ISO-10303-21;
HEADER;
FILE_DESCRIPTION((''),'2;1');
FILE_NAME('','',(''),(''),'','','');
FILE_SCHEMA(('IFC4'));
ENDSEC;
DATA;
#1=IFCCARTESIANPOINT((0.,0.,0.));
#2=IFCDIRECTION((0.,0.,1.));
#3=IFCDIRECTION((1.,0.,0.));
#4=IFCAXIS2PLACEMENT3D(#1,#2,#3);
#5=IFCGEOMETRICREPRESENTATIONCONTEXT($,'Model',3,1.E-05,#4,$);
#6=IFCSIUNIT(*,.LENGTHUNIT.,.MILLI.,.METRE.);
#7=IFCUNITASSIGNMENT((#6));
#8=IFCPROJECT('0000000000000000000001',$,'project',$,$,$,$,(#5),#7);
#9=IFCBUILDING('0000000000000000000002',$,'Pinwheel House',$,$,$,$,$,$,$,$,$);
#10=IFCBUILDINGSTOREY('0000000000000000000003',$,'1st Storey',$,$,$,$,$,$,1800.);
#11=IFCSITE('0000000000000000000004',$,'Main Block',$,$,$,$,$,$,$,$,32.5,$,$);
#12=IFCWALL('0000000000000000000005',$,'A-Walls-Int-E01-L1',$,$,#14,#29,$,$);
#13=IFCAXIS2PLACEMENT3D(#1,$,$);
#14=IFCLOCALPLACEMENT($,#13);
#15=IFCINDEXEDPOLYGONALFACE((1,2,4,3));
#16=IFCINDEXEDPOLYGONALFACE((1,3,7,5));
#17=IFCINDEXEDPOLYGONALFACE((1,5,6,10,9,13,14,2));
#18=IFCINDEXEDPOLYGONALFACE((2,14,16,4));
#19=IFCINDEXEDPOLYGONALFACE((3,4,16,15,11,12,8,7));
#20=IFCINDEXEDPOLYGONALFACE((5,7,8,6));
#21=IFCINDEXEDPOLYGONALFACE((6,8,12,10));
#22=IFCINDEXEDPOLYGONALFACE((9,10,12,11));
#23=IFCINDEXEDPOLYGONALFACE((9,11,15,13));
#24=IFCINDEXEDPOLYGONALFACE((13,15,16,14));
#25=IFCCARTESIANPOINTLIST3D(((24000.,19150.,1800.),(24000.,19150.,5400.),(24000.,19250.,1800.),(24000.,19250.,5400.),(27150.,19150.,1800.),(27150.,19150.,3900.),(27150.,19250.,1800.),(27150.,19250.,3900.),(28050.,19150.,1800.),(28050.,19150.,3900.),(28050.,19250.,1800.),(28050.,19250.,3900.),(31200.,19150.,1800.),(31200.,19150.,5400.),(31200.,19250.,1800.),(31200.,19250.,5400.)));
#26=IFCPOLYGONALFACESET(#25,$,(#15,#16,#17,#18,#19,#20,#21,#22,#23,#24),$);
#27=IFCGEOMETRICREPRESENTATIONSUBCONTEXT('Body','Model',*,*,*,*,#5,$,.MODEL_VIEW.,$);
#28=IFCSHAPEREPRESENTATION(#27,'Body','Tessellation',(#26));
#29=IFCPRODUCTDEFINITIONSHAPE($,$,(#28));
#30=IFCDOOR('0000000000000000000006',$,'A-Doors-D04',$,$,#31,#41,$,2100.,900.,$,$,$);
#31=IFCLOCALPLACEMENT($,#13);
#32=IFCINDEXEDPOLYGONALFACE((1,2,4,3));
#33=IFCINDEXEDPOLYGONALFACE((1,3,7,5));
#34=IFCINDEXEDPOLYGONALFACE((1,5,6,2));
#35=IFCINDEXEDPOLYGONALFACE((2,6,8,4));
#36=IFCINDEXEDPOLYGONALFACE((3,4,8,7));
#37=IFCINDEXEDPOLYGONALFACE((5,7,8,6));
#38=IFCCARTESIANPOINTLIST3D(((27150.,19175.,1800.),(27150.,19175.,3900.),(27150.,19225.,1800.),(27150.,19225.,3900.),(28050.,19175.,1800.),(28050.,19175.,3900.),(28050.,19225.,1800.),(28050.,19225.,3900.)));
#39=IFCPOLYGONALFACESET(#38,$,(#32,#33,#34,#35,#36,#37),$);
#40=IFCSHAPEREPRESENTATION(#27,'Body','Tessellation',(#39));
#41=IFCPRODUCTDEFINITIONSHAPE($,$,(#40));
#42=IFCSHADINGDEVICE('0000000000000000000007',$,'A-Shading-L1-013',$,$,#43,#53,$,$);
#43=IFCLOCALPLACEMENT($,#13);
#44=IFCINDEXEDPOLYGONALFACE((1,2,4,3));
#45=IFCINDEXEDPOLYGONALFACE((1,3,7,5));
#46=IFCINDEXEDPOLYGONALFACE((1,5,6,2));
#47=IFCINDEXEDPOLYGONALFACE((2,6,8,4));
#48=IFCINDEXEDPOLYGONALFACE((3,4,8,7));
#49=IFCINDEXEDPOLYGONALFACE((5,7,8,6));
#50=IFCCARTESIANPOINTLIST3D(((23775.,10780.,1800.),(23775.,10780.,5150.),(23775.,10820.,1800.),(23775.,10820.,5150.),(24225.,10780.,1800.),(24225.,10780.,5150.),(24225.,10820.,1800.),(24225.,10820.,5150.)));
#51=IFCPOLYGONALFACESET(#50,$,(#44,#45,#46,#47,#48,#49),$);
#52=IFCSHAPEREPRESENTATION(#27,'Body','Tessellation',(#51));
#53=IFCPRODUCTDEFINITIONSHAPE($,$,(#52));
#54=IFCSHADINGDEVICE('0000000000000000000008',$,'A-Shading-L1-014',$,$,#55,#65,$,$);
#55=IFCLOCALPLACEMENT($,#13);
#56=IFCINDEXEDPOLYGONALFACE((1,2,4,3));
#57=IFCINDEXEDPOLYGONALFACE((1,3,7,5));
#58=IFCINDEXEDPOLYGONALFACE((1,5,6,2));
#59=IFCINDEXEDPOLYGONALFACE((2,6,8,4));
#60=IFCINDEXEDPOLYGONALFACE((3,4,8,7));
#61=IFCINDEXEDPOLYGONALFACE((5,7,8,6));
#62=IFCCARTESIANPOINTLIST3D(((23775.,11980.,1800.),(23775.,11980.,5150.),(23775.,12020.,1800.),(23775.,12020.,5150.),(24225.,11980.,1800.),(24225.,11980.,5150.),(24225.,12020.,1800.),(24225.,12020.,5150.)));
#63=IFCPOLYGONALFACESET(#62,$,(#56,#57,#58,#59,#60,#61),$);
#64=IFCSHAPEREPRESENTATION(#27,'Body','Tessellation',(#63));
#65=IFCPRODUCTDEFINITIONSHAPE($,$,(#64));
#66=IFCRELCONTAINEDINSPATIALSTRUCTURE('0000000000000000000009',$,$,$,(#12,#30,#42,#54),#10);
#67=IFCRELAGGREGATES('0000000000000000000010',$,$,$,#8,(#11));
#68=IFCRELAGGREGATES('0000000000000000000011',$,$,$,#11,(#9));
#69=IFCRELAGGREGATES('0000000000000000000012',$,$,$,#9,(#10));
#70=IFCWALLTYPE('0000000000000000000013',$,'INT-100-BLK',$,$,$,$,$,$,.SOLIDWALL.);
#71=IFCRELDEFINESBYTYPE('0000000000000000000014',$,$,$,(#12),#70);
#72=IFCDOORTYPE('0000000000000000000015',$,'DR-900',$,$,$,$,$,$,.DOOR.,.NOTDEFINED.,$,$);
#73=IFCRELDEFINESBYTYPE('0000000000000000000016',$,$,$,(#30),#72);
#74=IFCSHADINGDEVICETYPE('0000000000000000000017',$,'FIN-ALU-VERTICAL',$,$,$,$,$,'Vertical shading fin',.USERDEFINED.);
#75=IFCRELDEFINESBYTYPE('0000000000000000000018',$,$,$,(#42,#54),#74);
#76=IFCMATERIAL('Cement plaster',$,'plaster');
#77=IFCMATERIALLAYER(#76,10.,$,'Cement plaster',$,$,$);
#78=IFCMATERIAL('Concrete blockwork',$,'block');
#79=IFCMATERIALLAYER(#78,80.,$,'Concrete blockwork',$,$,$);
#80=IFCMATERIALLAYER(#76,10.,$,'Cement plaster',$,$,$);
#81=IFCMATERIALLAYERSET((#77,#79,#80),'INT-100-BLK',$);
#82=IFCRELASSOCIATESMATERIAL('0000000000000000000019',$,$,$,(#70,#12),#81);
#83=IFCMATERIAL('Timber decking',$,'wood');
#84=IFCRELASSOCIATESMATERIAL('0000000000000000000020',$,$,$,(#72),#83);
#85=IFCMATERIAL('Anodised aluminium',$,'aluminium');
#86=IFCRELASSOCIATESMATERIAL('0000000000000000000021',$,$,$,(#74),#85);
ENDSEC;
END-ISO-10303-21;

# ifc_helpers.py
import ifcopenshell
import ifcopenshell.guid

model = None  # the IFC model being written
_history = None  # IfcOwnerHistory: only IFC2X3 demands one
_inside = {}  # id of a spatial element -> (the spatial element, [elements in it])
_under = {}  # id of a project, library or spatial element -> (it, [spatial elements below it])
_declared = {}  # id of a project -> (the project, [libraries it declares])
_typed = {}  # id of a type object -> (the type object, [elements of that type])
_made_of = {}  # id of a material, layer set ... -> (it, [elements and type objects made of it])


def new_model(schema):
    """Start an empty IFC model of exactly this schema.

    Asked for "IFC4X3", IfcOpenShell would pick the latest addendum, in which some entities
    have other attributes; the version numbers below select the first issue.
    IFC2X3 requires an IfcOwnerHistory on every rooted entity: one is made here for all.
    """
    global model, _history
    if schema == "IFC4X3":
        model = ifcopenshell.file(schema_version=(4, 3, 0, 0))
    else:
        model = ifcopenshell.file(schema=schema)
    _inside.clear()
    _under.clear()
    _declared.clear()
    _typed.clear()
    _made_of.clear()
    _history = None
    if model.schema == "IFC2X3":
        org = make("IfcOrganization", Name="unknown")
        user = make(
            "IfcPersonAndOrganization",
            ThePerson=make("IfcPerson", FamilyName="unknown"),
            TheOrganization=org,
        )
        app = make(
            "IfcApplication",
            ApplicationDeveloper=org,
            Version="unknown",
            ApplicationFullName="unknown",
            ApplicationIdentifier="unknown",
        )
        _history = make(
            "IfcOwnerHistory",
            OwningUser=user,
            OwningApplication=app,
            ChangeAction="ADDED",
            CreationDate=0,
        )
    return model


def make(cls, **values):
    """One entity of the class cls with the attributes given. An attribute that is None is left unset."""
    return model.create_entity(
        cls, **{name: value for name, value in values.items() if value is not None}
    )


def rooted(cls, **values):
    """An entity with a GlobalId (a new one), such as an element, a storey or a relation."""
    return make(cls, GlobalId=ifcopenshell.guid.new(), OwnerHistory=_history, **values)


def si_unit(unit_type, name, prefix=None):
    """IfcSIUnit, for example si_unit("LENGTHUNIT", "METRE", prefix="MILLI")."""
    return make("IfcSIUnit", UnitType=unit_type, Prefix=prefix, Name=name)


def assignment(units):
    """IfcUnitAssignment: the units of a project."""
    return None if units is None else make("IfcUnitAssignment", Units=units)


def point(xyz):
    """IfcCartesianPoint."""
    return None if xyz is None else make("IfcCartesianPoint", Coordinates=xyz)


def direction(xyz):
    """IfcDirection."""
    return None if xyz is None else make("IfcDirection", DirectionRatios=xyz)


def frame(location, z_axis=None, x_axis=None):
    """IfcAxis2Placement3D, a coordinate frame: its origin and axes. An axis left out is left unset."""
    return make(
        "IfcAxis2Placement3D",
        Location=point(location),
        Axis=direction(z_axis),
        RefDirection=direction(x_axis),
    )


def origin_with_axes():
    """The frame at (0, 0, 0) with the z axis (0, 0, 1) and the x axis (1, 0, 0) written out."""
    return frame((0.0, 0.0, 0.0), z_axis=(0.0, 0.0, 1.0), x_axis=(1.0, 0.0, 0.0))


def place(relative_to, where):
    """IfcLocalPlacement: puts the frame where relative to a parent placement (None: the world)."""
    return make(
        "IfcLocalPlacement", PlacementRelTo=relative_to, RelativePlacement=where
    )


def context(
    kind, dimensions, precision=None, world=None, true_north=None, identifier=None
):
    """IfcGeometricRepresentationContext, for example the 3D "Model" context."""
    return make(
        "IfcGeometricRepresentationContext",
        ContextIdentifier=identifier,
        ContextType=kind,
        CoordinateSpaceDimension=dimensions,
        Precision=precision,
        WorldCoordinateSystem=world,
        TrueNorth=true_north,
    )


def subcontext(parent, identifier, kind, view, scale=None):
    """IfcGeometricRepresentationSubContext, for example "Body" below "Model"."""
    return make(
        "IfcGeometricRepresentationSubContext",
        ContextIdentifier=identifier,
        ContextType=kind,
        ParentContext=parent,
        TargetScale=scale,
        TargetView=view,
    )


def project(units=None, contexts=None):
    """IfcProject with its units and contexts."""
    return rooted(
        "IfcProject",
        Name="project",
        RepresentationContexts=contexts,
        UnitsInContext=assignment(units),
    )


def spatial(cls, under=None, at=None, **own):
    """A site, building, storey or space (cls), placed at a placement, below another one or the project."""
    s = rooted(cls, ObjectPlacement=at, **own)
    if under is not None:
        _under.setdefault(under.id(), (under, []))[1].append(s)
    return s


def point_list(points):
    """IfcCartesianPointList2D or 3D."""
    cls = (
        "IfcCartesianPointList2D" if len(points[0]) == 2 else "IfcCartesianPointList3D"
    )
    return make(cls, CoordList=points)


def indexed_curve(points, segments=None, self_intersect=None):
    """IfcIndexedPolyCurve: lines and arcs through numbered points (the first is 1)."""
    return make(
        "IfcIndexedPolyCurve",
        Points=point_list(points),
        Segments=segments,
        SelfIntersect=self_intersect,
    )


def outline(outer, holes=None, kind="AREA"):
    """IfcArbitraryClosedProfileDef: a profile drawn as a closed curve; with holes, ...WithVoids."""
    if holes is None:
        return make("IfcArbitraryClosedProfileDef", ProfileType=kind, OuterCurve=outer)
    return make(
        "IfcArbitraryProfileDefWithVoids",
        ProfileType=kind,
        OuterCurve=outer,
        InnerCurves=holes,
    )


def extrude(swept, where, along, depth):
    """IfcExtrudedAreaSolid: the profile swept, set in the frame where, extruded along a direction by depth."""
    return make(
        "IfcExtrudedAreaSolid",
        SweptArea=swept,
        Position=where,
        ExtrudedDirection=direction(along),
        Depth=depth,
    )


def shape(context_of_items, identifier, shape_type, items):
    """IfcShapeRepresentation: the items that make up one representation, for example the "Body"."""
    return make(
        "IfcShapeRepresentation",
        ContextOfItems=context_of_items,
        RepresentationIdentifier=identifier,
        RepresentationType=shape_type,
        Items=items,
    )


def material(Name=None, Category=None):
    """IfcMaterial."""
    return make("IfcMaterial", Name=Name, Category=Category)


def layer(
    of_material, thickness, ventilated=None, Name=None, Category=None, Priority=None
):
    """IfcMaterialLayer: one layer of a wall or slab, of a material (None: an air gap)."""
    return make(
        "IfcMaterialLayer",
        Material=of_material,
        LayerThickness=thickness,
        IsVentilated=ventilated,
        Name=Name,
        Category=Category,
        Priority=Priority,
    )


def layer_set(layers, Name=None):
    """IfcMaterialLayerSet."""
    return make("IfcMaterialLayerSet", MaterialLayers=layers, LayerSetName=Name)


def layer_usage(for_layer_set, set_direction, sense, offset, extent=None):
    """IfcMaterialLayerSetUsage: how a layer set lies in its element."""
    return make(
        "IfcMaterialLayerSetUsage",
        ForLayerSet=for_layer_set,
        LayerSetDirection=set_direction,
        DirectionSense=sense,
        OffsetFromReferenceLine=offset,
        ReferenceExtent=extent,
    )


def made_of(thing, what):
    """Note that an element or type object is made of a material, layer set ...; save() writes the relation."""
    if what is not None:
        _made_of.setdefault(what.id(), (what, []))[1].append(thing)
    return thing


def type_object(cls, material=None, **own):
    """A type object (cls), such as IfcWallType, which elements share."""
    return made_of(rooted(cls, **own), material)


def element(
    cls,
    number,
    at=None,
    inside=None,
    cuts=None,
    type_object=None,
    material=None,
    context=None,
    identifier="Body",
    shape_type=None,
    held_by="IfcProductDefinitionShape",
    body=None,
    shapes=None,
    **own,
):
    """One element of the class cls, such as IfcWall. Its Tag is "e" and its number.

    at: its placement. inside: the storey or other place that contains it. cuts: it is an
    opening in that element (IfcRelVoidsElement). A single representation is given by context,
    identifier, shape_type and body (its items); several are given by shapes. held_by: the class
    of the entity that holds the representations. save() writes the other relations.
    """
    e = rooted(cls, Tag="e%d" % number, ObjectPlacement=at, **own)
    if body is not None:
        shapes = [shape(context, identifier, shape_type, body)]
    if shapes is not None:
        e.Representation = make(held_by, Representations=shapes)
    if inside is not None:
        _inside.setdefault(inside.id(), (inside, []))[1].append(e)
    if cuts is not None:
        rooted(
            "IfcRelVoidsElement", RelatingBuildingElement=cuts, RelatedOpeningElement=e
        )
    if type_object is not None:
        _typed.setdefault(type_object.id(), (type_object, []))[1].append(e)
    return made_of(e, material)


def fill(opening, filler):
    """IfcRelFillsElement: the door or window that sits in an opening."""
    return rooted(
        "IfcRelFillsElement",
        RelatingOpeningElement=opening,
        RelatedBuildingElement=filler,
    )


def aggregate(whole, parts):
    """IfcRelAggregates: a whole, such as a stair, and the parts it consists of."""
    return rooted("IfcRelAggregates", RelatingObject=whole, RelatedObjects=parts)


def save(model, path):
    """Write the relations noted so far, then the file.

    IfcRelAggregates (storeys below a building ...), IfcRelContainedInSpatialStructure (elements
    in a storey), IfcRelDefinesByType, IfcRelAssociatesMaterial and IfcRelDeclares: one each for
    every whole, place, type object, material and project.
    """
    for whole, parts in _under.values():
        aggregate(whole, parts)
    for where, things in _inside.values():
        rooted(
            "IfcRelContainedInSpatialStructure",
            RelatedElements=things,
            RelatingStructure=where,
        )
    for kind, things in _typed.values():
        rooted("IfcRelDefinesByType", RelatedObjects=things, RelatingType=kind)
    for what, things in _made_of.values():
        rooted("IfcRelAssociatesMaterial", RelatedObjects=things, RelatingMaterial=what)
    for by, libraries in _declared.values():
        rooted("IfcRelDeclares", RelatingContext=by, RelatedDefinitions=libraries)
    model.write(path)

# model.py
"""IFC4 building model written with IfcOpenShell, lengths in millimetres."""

from ifc_helpers import new_model, si_unit, frame, origin_with_axes, place, context, subcontext, project, spatial, indexed_curve, outline, extrude, material, layer, layer_set, layer_usage, type_object, element, fill, save


model = new_model("IFC4")

# Units and contexts
model_context = context("Model", 3, precision=1e-05, world=origin_with_axes())
body_context = subcontext(model_context, "Body", "Model", "MODEL_VIEW")
ifc_project = project(units=[si_unit("LENGTHUNIT", "METRE", prefix="MILLI")], contexts=[model_context])

# Site, building, storey
site = spatial("IfcSite", under=ifc_project, Name="Main Block", RefElevation=32.5)
building = spatial("IfcBuilding", under=site, Name="Pinwheel House")
storey = spatial("IfcBuildingStorey", under=building, Name="1st Storey", Elevation=1800.0)

# Shared definitions
ifc_material_1 = material(Name="Anodised aluminium", Category="aluminium")

# Shared definitions
ifc_material_2 = material(Name="Timber decking", Category="wood")

# Wall, opening, door
ifc_material_3 = material(Name="Cement plaster", Category="plaster")
ifc_layer_1 = layer(ifc_material_3, 10.0, Name="Cement plaster")
ifc_material_4 = material(Name="Concrete blockwork", Category="block")
ifc_layer_2 = layer(ifc_material_4, 80.0, Name="Concrete blockwork")
ifc_layer_3 = layer(ifc_material_3, 10.0, Name="Cement plaster")
ifc_layer_set_1 = layer_set([ifc_layer_1, ifc_layer_2, ifc_layer_3], Name="INT-100-BLK")
ifc_layer_usage_1 = layer_usage(ifc_layer_set_1, "AXIS2", "POSITIVE", 0.0)
wall_type_1 = type_object("IfcWallType", Name="INT-100-BLK", PredefinedType="SOLIDWALL", material=ifc_layer_set_1)
wall_1_placement = place(None, frame((24000.0, 19150.0, 1800.0), z_axis=(0.0, 0.0, 1.0), x_axis=(1.0, 0.0, 0.0)))
wall_1 = element("IfcWall", 1, at=wall_1_placement, inside=storey, type_object=wall_type_1, material=ifc_layer_usage_1, Name="A-Walls-Int-E01-L1", context=body_context, shape_type="SweptSolid", body=[
    extrude(outline(indexed_curve([(0.0, 0.0), (0.0, 100.0), (7200.0, 100.0), (7200.0, 0.0), (0.0, 0.0)], self_intersect=False)), origin_with_axes(), (0.0, 0.0, 1.0), 3600.0),
])
opening_1_placement = place(wall_1_placement, frame((3600.0, 50.0, 0.0), z_axis=(0.0, 0.0, 1.0), x_axis=(1.0, 0.0, 0.0)))
opening_1 = element("IfcOpeningElement", 2, at=opening_1_placement, cuts=wall_1, PredefinedType="OPENING", context=body_context, shape_type="SweptSolid", body=[
    extrude(outline(indexed_curve([(-450.0, -100.0), (450.0, -100.0), (450.0, 100.0), (-450.0, 100.0)])), None, (0.0, 0.0, 1.0), 2100.0),
])
door_type_1 = type_object("IfcDoorType", Name="DR-900", OperationType="NOTDEFINED", PredefinedType="DOOR", material=ifc_material_2)
door_1_placement = place(None, frame((27600.0, 19200.0, 1800.0), z_axis=(0.0, 0.0, 1.0), x_axis=(1.0, 0.0, 0.0)))
door_1 = element("IfcDoor", 3, at=door_1_placement, inside=storey, type_object=door_type_1, Name="A-Doors-D04", OverallHeight=2100.0, OverallWidth=900.0, context=body_context, shape_type="SweptSolid", body=[
    extrude(outline(indexed_curve([(-450.0, -25.0), (450.0, -25.0), (450.0, 25.0), (-450.0, 25.0)])), None, (0.0, 0.0, 1.0), 2100.0),
])
fill(opening_1, door_1)

# Shading devices
shading_device_type = type_object("IfcShadingDeviceType", Name="FIN-ALU-VERTICAL", ElementType="Vertical shading fin", PredefinedType="USERDEFINED", material=ifc_material_1)
for number, where, z_axis, x_axis, name in (
    (4, (24000.0, 10800.0, 1800.0), (0.0, 0.0, 1.0), (0.0, 1.0, 0.0), "A-Shading-L1-013"),
    (5, (24000.0, 12000.0, 1800.0), (0.0, 0.0, 1.0), (0.0, 1.0, 0.0), "A-Shading-L1-014"),
):
    element("IfcShadingDevice", number, at=place(None, frame(where, z_axis=z_axis, x_axis=x_axis)), inside=storey, type_object=shading_device_type, Name=name, context=body_context, shape_type="SweptSolid", body=[
        extrude(outline(indexed_curve([(-20.0, -225.0), (20.0, -225.0), (20.0, 225.0), (-20.0, 225.0)])), None, (0.0, 0.0, 1.0), 3350.0),
    ])

save(model, "model.ifc")
